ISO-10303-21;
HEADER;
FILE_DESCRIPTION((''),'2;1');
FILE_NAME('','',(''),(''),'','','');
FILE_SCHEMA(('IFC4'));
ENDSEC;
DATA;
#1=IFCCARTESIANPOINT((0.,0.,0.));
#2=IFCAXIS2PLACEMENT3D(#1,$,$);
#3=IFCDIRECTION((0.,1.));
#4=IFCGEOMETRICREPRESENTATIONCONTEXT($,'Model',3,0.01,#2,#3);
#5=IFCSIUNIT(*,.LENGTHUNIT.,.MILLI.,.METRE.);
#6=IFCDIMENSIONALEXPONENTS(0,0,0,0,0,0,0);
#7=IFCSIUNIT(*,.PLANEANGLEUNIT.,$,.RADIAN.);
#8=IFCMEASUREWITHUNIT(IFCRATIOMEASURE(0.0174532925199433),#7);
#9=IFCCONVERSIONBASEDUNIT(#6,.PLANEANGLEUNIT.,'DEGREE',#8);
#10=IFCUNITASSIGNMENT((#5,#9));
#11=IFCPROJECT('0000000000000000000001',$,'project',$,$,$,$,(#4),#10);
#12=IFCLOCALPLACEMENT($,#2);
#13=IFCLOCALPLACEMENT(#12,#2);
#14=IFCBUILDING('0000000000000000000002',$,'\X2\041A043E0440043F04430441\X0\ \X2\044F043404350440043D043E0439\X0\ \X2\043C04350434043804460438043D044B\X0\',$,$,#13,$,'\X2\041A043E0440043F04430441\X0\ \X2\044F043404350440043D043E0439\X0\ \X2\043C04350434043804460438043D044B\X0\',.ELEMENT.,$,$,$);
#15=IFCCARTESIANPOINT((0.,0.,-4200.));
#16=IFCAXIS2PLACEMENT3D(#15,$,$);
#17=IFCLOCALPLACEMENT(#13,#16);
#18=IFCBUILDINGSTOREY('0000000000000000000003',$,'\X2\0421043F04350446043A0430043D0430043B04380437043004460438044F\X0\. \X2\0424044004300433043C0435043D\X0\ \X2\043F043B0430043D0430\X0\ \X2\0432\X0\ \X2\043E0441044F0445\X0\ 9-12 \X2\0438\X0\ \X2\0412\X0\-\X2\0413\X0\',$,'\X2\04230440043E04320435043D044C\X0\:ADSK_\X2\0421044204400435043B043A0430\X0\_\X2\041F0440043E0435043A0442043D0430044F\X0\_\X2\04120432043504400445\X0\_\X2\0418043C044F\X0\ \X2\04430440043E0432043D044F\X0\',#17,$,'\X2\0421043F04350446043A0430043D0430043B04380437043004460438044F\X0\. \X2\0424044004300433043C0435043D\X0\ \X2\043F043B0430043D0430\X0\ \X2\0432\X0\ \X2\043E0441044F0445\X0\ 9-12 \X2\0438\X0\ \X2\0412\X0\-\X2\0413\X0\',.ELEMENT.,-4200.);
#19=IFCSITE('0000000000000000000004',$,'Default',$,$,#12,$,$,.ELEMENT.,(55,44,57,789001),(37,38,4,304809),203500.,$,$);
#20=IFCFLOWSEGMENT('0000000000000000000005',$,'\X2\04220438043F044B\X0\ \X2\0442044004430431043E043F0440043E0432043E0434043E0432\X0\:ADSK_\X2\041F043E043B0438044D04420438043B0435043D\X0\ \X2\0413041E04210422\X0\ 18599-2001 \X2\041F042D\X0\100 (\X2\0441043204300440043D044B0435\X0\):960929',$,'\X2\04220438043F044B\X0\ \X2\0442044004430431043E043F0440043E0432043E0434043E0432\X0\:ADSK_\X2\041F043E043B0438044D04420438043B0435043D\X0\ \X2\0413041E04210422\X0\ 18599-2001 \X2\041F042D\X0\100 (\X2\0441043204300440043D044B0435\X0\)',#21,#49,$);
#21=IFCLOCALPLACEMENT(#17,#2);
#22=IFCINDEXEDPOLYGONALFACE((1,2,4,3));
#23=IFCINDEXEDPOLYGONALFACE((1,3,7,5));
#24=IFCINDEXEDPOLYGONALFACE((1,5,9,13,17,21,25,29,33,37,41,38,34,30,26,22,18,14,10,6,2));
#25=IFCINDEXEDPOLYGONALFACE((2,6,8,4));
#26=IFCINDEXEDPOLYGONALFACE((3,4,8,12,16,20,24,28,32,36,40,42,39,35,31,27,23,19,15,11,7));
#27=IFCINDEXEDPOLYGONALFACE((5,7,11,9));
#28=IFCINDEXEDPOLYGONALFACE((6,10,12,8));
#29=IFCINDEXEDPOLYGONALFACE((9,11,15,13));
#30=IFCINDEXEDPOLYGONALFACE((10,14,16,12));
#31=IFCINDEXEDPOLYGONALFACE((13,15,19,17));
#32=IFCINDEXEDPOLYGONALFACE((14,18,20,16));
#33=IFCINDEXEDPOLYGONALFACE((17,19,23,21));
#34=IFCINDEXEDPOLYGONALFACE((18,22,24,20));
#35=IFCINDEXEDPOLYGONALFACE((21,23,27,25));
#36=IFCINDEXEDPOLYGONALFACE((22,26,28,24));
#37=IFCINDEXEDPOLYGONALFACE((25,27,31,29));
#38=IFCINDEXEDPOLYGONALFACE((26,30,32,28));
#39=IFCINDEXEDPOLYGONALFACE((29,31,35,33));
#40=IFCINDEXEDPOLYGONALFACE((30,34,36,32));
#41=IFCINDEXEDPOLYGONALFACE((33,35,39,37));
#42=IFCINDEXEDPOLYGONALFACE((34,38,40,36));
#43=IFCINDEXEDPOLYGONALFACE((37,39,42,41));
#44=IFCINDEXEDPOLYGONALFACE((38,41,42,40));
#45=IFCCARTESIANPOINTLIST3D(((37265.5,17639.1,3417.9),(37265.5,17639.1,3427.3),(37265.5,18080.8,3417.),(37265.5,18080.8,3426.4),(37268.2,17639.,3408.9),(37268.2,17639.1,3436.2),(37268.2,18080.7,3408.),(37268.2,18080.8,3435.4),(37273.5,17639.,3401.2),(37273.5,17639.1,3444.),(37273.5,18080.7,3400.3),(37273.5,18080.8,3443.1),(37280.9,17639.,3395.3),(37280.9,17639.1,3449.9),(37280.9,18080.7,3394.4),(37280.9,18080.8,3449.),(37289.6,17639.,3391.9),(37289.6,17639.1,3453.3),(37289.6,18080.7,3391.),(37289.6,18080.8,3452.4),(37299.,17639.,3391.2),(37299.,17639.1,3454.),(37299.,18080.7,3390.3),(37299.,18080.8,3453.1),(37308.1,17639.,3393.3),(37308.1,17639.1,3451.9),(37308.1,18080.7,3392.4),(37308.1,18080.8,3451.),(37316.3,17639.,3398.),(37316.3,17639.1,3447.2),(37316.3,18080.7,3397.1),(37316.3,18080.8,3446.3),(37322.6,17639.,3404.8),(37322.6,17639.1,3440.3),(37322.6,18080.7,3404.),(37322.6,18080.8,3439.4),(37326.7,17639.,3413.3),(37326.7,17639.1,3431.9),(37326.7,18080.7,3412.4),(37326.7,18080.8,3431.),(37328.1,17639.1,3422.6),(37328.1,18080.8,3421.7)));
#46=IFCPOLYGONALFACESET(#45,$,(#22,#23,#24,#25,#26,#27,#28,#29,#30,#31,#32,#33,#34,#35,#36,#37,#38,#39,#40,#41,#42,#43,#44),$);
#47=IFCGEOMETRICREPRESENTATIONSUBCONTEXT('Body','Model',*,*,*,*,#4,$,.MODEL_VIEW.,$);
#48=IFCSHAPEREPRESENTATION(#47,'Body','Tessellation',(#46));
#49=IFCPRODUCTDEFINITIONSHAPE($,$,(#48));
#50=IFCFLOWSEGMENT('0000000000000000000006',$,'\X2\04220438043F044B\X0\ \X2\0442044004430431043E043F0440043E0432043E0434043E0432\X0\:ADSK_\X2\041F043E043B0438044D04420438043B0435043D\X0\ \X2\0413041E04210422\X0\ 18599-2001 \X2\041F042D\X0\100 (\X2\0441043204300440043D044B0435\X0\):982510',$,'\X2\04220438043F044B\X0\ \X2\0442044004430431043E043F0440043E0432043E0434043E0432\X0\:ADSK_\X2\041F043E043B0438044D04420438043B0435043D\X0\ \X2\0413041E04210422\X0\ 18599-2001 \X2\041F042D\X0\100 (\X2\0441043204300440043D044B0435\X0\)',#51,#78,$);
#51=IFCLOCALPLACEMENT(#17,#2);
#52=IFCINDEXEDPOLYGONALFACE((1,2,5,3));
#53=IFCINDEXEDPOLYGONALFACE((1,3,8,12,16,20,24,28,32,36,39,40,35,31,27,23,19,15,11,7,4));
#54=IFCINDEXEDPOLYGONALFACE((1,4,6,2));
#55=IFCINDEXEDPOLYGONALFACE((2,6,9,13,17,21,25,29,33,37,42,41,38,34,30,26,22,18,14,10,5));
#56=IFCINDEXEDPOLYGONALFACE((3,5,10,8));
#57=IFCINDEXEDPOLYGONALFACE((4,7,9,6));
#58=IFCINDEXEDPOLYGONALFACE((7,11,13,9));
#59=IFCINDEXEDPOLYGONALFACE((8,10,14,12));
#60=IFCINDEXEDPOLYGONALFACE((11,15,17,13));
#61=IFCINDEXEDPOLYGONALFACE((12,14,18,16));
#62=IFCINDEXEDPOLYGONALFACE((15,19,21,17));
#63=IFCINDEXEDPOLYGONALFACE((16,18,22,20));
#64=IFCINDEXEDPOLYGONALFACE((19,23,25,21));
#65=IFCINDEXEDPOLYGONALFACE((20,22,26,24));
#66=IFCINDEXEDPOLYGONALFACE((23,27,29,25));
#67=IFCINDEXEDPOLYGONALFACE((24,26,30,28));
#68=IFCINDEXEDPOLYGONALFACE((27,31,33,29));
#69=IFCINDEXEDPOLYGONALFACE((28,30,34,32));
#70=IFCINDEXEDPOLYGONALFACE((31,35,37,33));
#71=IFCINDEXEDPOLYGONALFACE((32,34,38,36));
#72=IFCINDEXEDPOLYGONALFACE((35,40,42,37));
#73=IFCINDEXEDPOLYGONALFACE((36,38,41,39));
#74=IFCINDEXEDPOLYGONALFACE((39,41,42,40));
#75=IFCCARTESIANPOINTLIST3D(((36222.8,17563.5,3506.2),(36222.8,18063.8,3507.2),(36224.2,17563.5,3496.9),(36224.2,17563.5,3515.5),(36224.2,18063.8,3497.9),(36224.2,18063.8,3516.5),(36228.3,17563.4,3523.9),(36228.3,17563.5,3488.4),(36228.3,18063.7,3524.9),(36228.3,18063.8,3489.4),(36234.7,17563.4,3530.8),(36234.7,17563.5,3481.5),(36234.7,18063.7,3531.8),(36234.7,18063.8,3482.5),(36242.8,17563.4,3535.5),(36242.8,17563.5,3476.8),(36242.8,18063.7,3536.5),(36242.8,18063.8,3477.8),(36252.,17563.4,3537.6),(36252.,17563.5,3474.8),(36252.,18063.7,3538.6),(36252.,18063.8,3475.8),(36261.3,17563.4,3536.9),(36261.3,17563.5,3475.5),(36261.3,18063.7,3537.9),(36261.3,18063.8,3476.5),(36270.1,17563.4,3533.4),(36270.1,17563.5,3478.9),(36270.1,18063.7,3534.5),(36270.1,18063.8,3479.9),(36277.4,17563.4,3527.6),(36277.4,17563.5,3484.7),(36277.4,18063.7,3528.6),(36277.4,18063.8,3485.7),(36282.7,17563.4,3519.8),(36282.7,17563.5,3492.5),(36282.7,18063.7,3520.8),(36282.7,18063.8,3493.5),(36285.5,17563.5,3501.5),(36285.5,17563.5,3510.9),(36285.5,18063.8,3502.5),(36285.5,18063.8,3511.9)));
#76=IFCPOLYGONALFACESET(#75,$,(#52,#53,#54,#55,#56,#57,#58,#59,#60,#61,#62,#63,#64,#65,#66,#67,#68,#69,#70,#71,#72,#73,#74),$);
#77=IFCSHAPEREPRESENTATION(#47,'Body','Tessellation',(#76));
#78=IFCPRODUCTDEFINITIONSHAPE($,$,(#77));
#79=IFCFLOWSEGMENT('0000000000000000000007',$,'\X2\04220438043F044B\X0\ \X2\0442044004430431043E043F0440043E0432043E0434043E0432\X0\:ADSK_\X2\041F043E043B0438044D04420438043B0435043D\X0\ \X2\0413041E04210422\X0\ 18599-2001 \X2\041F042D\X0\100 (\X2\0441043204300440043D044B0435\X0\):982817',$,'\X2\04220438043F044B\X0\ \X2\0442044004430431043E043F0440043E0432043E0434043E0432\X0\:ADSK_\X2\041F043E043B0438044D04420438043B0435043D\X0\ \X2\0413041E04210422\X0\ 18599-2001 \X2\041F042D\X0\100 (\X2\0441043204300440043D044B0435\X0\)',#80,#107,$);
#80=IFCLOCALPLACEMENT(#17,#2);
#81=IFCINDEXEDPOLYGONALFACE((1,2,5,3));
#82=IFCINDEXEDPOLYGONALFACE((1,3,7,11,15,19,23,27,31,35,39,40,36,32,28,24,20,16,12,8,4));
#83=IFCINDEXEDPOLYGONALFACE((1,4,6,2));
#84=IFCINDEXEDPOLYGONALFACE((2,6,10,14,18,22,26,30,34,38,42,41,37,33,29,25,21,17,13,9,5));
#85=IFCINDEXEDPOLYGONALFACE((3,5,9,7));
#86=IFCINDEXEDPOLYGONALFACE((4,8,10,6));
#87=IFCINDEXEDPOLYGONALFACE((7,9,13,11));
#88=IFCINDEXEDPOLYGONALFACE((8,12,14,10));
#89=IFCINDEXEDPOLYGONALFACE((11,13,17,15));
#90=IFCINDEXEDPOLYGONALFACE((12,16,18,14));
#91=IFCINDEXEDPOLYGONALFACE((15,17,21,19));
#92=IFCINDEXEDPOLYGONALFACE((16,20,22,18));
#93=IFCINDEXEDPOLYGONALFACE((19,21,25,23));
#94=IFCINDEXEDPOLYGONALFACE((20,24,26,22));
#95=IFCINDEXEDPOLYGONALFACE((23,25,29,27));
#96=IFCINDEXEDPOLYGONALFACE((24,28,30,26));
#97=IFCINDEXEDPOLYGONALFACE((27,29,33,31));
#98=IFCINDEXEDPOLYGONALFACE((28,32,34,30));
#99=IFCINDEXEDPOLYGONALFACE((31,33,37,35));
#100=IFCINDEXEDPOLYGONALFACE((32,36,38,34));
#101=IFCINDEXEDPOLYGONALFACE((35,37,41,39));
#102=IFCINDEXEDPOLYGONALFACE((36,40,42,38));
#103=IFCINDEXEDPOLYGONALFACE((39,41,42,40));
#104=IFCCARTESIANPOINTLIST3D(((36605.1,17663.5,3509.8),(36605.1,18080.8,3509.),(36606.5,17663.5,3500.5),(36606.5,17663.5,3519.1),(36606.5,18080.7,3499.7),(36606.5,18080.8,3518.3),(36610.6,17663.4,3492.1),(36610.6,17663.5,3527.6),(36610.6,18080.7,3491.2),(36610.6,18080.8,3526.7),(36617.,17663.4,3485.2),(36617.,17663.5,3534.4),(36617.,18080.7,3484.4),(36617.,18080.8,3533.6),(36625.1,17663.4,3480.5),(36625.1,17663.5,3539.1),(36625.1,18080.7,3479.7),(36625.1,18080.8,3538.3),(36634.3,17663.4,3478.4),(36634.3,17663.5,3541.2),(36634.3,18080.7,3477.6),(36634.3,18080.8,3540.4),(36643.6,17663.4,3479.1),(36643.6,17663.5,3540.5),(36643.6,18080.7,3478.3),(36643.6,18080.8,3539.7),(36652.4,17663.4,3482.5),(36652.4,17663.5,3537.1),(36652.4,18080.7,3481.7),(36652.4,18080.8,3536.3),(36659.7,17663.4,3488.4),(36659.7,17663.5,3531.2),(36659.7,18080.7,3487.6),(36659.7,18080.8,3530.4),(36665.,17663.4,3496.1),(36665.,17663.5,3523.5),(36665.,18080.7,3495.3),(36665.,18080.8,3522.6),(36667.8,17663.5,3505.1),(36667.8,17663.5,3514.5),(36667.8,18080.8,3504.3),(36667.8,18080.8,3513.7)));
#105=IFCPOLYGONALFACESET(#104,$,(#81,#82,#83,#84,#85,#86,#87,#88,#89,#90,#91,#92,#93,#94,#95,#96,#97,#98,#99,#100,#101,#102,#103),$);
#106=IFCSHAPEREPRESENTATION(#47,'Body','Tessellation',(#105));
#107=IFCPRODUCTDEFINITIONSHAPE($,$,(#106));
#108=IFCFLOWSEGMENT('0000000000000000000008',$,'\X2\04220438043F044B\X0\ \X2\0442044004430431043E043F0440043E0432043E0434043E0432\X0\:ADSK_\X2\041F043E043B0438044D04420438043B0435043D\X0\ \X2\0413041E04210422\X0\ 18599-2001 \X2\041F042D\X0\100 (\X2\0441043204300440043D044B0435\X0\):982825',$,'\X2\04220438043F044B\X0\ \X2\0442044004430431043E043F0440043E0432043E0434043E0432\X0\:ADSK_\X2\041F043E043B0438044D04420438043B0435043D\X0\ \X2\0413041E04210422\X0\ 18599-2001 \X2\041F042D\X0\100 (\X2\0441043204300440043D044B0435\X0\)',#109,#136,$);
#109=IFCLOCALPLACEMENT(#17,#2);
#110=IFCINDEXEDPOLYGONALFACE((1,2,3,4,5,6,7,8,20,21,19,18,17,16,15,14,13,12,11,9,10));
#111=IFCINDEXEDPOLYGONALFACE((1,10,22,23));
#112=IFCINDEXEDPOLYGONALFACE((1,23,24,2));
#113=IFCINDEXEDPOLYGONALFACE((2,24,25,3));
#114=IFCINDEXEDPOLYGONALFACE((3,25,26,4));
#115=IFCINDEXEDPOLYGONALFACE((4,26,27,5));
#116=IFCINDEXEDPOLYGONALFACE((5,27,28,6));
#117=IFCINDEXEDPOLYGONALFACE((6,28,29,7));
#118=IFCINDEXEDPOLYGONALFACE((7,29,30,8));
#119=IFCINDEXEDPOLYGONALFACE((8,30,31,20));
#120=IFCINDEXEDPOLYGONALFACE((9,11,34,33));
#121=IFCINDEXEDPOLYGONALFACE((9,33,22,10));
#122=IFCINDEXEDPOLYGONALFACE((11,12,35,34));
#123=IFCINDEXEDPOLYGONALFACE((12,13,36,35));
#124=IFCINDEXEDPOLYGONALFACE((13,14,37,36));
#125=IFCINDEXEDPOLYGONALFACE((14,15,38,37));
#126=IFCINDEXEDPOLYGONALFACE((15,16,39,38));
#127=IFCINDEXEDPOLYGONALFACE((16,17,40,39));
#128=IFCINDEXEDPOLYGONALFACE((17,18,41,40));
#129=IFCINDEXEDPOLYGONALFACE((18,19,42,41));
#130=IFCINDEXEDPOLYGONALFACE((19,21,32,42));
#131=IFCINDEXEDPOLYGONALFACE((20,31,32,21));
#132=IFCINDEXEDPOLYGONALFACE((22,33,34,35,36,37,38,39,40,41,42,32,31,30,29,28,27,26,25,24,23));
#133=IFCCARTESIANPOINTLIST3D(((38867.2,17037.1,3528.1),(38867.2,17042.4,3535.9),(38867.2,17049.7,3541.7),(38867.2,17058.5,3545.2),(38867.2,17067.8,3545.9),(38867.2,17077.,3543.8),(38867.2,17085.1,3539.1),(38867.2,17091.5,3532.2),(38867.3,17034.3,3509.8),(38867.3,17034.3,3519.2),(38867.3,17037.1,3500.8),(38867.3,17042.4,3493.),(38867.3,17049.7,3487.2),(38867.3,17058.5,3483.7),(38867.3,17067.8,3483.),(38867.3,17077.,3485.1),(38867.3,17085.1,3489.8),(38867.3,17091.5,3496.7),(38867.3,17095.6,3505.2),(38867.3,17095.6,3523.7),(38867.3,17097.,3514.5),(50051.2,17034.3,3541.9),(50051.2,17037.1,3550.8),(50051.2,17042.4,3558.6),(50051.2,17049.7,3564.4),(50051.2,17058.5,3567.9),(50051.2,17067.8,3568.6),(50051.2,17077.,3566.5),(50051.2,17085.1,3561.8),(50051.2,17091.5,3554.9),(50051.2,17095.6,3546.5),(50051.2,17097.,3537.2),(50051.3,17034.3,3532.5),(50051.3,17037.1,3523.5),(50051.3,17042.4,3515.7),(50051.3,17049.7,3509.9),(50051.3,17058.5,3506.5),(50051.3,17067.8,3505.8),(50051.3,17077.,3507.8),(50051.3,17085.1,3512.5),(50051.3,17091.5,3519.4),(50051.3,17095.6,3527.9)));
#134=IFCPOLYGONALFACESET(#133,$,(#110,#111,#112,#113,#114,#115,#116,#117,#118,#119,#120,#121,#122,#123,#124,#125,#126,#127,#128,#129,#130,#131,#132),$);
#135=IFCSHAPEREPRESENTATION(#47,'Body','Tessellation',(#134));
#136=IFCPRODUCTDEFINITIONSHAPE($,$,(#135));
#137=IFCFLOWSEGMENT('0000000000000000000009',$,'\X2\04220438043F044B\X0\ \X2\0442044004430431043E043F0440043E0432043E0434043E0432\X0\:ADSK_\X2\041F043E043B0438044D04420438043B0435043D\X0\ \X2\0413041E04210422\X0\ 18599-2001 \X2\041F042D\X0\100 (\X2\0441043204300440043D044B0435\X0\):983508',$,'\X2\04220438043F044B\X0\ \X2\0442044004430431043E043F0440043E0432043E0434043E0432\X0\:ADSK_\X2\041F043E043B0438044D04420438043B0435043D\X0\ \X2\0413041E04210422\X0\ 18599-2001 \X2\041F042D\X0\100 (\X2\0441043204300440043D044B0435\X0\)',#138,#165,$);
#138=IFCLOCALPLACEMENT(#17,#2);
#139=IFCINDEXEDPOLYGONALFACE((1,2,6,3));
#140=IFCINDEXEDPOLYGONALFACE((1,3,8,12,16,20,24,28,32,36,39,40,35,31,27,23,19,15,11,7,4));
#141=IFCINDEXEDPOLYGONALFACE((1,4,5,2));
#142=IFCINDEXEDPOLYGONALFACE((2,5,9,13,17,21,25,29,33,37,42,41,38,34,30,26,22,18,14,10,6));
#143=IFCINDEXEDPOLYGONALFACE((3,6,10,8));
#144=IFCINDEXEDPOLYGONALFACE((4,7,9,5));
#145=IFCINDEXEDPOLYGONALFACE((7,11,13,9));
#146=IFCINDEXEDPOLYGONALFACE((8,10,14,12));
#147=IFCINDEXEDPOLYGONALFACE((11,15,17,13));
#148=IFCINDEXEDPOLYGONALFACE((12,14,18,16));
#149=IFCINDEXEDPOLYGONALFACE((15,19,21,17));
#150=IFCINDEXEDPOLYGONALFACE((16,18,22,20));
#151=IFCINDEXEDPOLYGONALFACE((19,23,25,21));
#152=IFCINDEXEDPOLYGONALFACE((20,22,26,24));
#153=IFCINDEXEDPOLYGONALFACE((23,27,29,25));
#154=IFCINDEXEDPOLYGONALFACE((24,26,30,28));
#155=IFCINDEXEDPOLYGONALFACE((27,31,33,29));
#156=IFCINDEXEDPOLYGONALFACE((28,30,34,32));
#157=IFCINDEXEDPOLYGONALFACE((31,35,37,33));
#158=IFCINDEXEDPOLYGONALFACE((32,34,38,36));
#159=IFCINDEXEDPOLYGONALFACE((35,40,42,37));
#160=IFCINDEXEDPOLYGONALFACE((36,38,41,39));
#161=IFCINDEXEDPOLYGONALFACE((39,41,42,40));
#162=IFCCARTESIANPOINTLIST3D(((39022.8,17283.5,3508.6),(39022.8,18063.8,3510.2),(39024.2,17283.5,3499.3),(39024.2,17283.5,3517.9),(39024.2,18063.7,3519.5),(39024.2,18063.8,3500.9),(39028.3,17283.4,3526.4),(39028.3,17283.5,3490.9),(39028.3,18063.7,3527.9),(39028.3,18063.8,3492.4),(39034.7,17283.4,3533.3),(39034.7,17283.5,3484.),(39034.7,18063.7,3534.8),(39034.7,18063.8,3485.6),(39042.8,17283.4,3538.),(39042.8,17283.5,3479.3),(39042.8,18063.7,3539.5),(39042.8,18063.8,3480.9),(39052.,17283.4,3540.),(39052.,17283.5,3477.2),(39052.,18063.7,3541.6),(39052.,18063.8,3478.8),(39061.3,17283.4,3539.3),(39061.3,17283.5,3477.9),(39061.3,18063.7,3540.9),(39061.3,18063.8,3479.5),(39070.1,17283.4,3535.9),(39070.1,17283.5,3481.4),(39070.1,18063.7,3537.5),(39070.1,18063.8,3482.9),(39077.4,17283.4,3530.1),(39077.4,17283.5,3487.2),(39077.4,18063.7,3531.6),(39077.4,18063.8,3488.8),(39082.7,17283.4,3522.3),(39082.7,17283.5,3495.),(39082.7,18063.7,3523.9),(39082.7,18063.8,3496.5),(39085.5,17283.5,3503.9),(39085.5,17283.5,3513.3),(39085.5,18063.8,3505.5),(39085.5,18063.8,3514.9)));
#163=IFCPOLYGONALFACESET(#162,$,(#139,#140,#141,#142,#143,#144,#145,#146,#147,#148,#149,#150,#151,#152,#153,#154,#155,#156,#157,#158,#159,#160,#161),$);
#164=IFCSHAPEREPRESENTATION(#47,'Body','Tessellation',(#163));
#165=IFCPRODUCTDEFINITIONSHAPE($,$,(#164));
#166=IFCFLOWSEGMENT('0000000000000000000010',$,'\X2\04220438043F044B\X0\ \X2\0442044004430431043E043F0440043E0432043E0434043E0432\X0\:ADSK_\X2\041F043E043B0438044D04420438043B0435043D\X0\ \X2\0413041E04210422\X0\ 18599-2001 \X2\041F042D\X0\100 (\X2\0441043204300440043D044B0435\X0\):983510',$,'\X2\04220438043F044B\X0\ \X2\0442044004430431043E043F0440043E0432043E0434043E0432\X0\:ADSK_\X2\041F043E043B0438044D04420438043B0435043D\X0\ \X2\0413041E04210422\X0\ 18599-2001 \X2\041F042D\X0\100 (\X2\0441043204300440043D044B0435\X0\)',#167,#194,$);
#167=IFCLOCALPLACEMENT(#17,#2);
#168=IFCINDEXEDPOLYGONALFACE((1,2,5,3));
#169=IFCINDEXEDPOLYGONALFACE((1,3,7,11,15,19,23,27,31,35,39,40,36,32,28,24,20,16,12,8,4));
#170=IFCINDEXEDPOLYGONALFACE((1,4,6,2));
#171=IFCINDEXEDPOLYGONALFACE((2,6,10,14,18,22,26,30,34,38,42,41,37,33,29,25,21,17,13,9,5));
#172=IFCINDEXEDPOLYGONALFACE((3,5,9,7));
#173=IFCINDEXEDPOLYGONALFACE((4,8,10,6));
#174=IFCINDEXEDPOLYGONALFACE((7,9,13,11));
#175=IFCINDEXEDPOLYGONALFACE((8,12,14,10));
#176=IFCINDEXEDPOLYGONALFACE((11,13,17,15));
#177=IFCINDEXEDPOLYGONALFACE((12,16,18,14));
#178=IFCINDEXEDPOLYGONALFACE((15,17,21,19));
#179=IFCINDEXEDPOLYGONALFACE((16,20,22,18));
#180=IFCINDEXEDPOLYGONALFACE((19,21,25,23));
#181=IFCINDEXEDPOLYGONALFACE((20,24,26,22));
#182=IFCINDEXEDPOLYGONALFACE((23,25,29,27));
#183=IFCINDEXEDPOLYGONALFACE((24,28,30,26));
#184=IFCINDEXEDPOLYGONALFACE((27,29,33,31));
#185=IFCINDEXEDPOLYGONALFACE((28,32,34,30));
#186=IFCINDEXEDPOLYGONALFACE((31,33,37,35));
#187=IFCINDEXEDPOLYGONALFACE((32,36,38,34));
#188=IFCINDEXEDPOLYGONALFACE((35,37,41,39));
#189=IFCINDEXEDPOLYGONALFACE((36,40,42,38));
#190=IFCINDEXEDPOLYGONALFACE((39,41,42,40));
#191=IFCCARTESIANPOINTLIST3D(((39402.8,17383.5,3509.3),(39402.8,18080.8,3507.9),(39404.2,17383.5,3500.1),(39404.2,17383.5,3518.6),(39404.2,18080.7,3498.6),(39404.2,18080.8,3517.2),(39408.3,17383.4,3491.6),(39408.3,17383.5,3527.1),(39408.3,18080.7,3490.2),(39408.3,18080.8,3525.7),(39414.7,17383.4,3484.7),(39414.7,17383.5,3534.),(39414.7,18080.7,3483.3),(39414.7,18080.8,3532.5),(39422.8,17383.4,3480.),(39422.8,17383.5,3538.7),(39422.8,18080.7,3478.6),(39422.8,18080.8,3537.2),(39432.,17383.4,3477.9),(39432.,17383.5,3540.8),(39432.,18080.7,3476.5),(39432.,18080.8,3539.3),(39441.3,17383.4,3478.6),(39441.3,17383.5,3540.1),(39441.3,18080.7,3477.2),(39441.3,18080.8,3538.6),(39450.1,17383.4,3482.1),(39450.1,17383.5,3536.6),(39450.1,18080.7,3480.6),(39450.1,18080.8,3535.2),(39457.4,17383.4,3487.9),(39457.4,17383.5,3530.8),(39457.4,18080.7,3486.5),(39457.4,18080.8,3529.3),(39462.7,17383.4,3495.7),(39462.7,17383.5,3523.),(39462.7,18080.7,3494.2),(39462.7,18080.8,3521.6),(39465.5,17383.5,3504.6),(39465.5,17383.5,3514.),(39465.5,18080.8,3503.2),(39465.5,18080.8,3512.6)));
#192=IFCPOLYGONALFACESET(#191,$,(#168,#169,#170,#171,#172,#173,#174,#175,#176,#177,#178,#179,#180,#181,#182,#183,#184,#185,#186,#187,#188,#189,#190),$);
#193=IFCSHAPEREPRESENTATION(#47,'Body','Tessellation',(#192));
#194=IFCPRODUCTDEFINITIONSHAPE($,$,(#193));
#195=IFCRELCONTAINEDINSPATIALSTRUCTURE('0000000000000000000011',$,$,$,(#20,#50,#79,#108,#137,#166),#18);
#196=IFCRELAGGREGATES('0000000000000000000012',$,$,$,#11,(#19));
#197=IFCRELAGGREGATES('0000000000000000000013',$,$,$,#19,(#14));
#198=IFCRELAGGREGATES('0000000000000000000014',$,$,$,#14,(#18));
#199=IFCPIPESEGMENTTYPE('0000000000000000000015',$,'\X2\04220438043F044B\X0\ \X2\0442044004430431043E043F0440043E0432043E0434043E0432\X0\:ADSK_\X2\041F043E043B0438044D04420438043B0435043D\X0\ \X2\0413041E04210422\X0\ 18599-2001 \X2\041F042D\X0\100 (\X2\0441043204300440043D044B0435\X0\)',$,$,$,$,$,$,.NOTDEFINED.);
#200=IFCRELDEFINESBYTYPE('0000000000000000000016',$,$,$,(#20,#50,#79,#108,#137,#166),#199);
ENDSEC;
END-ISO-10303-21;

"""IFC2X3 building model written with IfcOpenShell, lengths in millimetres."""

from ifc_helpers import new_model, entity, si_unit, converted_unit, direction, frame, origin, origin_2d_with_axis, place, context, subcontext, project, spatial, circle, extrude, type_object, element, save


model = new_model("IFC2X3")

# Units and contexts
model_context = context("Model", 3, precision=0.01, world=origin(), true_north=direction((0.0, 1.0)))
body_context = subcontext(model_context, "Body", "Model", "MODEL_VIEW")
ifc_project = project(units=[si_unit("LENGTHUNIT", "METRE", prefix="MILLI"), converted_unit("PLANEANGLEUNIT", "DEGREE", entity("IfcRatioMeasure", 0.0174532925199433), si_unit("PLANEANGLEUNIT", "RADIAN"), dimensions=[0, 0, 0, 0, 0, 0, 0])], contexts=[model_context])

# Site, building, storey
site_placement = place(None, origin())
site = spatial("IfcSite", under=ifc_project, at=site_placement, Name="Default", CompositionType="ELEMENT", RefLatitude=(55, 44, 57, 789001), RefLongitude=(37, 38, 4, 304809), RefElevation=203500.0)
building_placement = place(site_placement, origin())
building = spatial("IfcBuilding", under=site, at=building_placement, Name="Корпус ядерной медицины", LongName="Корпус ядерной медицины", CompositionType="ELEMENT")
storey_placement = place(building_placement, frame((0.0, 0.0, -4200.0)))
storey = spatial("IfcBuildingStorey", under=building, at=storey_placement, Name="Спецканализация. Фрагмен плана в осях 9-12 и В-Г", ObjectType="Уровень:ADSK_Стрелка_Проектная_Вверх_Имя уровня", LongName="Спецканализация. Фрагмен плана в осях 9-12 и В-Г", CompositionType="ELEMENT", Elevation=-4200.0)

# Flow segments
pipe_segment_type = type_object("IfcPipeSegmentType", Name="Типы трубопроводов:ADSK_Полиэтилен ГОСТ 18599-2001 ПЭ100 (сварные)", PredefinedType="NOTDEFINED")
flow_segment_1_placement = place(storey_placement, frame((37263.5, 17639.0, 3388.6)))
element("IfcFlowSegment", 1, at=flow_segment_1_placement, inside=storey, type_object=pipe_segment_type, Name="Типы трубопроводов:ADSK_Полиэтилен ГОСТ 18599-2001 ПЭ100 (сварные):960929", ObjectType="Типы трубопроводов:ADSK_Полиэтилен ГОСТ 18599-2001 ПЭ100 (сварные)", context=body_context, shape_type="SweptSolid", body=[
    extrude(circle(Radius=31.5, at=origin_2d_with_axis()), frame((33.1, 0.1, 34.0), z_axis=(0.0, 0.999998, -0.001981), x_axis=(1.0, 0.0, 0.0)), (0.0, 0.0, 1.0), 441.7),
])
flow_segment_2_placement = place(storey_placement, frame((36221.2, 17563.4, 3473.1)))
element("IfcFlowSegment", 2, at=flow_segment_2_placement, inside=storey, type_object=pipe_segment_type, Name="Типы трубопроводов:ADSK_Полиэтилен ГОСТ 18599-2001 ПЭ100 (сварные):982510", ObjectType="Типы трубопроводов:ADSK_Полиэтилен ГОСТ 18599-2001 ПЭ100 (сварные)", context=body_context, shape_type="SweptSolid", body=[
    extrude(circle(Radius=31.5, at=origin_2d_with_axis()), frame((33.1, 0.1, 33.1), z_axis=(0.0, 0.999998, 0.002), x_axis=(-1.0, 0.0, 0.0)), (0.0, 0.0, 1.0), 500.3),
])
flow_segment_3_placement = place(storey_placement, frame((36603.5, 17663.4, 3475.9)))
element("IfcFlowSegment", 3, at=flow_segment_3_placement, inside=storey, type_object=pipe_segment_type, Name="Типы трубопроводов:ADSK_Полиэтилен ГОСТ 18599-2001 ПЭ100 (сварные):982817", ObjectType="Типы трубопроводов:ADSK_Полиэтилен ГОСТ 18599-2001 ПЭ100 (сварные)", context=body_context, shape_type="SweptSolid", body=[
    extrude(circle(Radius=31.5, at=origin_2d_with_axis()), frame((33.1, 417.4, 33.1), z_axis=(0.0, -0.999998, 0.002), x_axis=(-1.0, 0.0, 0.0)), (0.0, 0.0, 1.0), 417.3),
])
flow_segment_4_placement = place(storey_placement, frame((38867.2, 17032.4, 3481.4)))
element("IfcFlowSegment", 4, at=flow_segment_4_placement, inside=storey, type_object=pipe_segment_type, Name="Типы трубопроводов:ADSK_Полиэтилен ГОСТ 18599-2001 ПЭ100 (сварные):982825", ObjectType="Типы трубопроводов:ADSK_Полиэтилен ГОСТ 18599-2001 ПЭ100 (сварные)", context=body_context, shape_type="SweptSolid", body=[
    extrude(circle(Radius=31.5, at=origin_2d_with_axis()), frame((0.1, 33.1, 33.1), z_axis=(0.999998, 0.0, 0.002031), x_axis=(0.0, 1.0, 0.0)), (0.0, 0.0, 1.0), 11184.0),
])
flow_segment_5_placement = place(storey_placement, frame((39021.2, 17283.4, 3475.5)))
element("IfcFlowSegment", 5, at=flow_segment_5_placement, inside=storey, type_object=pipe_segment_type, Name="Типы трубопроводов:ADSK_Полиэтилен ГОСТ 18599-2001 ПЭ100 (сварные):983508", ObjectType="Типы трубопроводов:ADSK_Полиэтилен ГОСТ 18599-2001 ПЭ100 (сварные)", context=body_context, shape_type="SweptSolid", body=[
    extrude(circle(Radius=31.5, at=origin_2d_with_axis()), frame((33.1, 0.1, 33.1), z_axis=(0.0, 0.999998, 0.002), x_axis=(-1.0, 0.0, 0.0)), (0.0, 0.0, 1.0), 780.3),
])
flow_segment_6_placement = place(storey_placement, frame((39401.2, 17383.4, 3474.8)))
element("IfcFlowSegment", 6, at=flow_segment_6_placement, inside=storey, type_object=pipe_segment_type, Name="Типы трубопроводов:ADSK_Полиэтилен ГОСТ 18599-2001 ПЭ100 (сварные):983510", ObjectType="Типы трубопроводов:ADSK_Полиэтилен ГОСТ 18599-2001 ПЭ100 (сварные)", context=body_context, shape_type="SweptSolid", body=[
    extrude(circle(Radius=31.5, at=origin_2d_with_axis()), frame((33.1, 0.1, 34.5), z_axis=(0.000002, 0.999998, -0.00204), x_axis=(-1.0, 0.000002, 0.0)), (0.0, 0.0, 1.0), 697.3),
])

save(model, "model.ifc")
